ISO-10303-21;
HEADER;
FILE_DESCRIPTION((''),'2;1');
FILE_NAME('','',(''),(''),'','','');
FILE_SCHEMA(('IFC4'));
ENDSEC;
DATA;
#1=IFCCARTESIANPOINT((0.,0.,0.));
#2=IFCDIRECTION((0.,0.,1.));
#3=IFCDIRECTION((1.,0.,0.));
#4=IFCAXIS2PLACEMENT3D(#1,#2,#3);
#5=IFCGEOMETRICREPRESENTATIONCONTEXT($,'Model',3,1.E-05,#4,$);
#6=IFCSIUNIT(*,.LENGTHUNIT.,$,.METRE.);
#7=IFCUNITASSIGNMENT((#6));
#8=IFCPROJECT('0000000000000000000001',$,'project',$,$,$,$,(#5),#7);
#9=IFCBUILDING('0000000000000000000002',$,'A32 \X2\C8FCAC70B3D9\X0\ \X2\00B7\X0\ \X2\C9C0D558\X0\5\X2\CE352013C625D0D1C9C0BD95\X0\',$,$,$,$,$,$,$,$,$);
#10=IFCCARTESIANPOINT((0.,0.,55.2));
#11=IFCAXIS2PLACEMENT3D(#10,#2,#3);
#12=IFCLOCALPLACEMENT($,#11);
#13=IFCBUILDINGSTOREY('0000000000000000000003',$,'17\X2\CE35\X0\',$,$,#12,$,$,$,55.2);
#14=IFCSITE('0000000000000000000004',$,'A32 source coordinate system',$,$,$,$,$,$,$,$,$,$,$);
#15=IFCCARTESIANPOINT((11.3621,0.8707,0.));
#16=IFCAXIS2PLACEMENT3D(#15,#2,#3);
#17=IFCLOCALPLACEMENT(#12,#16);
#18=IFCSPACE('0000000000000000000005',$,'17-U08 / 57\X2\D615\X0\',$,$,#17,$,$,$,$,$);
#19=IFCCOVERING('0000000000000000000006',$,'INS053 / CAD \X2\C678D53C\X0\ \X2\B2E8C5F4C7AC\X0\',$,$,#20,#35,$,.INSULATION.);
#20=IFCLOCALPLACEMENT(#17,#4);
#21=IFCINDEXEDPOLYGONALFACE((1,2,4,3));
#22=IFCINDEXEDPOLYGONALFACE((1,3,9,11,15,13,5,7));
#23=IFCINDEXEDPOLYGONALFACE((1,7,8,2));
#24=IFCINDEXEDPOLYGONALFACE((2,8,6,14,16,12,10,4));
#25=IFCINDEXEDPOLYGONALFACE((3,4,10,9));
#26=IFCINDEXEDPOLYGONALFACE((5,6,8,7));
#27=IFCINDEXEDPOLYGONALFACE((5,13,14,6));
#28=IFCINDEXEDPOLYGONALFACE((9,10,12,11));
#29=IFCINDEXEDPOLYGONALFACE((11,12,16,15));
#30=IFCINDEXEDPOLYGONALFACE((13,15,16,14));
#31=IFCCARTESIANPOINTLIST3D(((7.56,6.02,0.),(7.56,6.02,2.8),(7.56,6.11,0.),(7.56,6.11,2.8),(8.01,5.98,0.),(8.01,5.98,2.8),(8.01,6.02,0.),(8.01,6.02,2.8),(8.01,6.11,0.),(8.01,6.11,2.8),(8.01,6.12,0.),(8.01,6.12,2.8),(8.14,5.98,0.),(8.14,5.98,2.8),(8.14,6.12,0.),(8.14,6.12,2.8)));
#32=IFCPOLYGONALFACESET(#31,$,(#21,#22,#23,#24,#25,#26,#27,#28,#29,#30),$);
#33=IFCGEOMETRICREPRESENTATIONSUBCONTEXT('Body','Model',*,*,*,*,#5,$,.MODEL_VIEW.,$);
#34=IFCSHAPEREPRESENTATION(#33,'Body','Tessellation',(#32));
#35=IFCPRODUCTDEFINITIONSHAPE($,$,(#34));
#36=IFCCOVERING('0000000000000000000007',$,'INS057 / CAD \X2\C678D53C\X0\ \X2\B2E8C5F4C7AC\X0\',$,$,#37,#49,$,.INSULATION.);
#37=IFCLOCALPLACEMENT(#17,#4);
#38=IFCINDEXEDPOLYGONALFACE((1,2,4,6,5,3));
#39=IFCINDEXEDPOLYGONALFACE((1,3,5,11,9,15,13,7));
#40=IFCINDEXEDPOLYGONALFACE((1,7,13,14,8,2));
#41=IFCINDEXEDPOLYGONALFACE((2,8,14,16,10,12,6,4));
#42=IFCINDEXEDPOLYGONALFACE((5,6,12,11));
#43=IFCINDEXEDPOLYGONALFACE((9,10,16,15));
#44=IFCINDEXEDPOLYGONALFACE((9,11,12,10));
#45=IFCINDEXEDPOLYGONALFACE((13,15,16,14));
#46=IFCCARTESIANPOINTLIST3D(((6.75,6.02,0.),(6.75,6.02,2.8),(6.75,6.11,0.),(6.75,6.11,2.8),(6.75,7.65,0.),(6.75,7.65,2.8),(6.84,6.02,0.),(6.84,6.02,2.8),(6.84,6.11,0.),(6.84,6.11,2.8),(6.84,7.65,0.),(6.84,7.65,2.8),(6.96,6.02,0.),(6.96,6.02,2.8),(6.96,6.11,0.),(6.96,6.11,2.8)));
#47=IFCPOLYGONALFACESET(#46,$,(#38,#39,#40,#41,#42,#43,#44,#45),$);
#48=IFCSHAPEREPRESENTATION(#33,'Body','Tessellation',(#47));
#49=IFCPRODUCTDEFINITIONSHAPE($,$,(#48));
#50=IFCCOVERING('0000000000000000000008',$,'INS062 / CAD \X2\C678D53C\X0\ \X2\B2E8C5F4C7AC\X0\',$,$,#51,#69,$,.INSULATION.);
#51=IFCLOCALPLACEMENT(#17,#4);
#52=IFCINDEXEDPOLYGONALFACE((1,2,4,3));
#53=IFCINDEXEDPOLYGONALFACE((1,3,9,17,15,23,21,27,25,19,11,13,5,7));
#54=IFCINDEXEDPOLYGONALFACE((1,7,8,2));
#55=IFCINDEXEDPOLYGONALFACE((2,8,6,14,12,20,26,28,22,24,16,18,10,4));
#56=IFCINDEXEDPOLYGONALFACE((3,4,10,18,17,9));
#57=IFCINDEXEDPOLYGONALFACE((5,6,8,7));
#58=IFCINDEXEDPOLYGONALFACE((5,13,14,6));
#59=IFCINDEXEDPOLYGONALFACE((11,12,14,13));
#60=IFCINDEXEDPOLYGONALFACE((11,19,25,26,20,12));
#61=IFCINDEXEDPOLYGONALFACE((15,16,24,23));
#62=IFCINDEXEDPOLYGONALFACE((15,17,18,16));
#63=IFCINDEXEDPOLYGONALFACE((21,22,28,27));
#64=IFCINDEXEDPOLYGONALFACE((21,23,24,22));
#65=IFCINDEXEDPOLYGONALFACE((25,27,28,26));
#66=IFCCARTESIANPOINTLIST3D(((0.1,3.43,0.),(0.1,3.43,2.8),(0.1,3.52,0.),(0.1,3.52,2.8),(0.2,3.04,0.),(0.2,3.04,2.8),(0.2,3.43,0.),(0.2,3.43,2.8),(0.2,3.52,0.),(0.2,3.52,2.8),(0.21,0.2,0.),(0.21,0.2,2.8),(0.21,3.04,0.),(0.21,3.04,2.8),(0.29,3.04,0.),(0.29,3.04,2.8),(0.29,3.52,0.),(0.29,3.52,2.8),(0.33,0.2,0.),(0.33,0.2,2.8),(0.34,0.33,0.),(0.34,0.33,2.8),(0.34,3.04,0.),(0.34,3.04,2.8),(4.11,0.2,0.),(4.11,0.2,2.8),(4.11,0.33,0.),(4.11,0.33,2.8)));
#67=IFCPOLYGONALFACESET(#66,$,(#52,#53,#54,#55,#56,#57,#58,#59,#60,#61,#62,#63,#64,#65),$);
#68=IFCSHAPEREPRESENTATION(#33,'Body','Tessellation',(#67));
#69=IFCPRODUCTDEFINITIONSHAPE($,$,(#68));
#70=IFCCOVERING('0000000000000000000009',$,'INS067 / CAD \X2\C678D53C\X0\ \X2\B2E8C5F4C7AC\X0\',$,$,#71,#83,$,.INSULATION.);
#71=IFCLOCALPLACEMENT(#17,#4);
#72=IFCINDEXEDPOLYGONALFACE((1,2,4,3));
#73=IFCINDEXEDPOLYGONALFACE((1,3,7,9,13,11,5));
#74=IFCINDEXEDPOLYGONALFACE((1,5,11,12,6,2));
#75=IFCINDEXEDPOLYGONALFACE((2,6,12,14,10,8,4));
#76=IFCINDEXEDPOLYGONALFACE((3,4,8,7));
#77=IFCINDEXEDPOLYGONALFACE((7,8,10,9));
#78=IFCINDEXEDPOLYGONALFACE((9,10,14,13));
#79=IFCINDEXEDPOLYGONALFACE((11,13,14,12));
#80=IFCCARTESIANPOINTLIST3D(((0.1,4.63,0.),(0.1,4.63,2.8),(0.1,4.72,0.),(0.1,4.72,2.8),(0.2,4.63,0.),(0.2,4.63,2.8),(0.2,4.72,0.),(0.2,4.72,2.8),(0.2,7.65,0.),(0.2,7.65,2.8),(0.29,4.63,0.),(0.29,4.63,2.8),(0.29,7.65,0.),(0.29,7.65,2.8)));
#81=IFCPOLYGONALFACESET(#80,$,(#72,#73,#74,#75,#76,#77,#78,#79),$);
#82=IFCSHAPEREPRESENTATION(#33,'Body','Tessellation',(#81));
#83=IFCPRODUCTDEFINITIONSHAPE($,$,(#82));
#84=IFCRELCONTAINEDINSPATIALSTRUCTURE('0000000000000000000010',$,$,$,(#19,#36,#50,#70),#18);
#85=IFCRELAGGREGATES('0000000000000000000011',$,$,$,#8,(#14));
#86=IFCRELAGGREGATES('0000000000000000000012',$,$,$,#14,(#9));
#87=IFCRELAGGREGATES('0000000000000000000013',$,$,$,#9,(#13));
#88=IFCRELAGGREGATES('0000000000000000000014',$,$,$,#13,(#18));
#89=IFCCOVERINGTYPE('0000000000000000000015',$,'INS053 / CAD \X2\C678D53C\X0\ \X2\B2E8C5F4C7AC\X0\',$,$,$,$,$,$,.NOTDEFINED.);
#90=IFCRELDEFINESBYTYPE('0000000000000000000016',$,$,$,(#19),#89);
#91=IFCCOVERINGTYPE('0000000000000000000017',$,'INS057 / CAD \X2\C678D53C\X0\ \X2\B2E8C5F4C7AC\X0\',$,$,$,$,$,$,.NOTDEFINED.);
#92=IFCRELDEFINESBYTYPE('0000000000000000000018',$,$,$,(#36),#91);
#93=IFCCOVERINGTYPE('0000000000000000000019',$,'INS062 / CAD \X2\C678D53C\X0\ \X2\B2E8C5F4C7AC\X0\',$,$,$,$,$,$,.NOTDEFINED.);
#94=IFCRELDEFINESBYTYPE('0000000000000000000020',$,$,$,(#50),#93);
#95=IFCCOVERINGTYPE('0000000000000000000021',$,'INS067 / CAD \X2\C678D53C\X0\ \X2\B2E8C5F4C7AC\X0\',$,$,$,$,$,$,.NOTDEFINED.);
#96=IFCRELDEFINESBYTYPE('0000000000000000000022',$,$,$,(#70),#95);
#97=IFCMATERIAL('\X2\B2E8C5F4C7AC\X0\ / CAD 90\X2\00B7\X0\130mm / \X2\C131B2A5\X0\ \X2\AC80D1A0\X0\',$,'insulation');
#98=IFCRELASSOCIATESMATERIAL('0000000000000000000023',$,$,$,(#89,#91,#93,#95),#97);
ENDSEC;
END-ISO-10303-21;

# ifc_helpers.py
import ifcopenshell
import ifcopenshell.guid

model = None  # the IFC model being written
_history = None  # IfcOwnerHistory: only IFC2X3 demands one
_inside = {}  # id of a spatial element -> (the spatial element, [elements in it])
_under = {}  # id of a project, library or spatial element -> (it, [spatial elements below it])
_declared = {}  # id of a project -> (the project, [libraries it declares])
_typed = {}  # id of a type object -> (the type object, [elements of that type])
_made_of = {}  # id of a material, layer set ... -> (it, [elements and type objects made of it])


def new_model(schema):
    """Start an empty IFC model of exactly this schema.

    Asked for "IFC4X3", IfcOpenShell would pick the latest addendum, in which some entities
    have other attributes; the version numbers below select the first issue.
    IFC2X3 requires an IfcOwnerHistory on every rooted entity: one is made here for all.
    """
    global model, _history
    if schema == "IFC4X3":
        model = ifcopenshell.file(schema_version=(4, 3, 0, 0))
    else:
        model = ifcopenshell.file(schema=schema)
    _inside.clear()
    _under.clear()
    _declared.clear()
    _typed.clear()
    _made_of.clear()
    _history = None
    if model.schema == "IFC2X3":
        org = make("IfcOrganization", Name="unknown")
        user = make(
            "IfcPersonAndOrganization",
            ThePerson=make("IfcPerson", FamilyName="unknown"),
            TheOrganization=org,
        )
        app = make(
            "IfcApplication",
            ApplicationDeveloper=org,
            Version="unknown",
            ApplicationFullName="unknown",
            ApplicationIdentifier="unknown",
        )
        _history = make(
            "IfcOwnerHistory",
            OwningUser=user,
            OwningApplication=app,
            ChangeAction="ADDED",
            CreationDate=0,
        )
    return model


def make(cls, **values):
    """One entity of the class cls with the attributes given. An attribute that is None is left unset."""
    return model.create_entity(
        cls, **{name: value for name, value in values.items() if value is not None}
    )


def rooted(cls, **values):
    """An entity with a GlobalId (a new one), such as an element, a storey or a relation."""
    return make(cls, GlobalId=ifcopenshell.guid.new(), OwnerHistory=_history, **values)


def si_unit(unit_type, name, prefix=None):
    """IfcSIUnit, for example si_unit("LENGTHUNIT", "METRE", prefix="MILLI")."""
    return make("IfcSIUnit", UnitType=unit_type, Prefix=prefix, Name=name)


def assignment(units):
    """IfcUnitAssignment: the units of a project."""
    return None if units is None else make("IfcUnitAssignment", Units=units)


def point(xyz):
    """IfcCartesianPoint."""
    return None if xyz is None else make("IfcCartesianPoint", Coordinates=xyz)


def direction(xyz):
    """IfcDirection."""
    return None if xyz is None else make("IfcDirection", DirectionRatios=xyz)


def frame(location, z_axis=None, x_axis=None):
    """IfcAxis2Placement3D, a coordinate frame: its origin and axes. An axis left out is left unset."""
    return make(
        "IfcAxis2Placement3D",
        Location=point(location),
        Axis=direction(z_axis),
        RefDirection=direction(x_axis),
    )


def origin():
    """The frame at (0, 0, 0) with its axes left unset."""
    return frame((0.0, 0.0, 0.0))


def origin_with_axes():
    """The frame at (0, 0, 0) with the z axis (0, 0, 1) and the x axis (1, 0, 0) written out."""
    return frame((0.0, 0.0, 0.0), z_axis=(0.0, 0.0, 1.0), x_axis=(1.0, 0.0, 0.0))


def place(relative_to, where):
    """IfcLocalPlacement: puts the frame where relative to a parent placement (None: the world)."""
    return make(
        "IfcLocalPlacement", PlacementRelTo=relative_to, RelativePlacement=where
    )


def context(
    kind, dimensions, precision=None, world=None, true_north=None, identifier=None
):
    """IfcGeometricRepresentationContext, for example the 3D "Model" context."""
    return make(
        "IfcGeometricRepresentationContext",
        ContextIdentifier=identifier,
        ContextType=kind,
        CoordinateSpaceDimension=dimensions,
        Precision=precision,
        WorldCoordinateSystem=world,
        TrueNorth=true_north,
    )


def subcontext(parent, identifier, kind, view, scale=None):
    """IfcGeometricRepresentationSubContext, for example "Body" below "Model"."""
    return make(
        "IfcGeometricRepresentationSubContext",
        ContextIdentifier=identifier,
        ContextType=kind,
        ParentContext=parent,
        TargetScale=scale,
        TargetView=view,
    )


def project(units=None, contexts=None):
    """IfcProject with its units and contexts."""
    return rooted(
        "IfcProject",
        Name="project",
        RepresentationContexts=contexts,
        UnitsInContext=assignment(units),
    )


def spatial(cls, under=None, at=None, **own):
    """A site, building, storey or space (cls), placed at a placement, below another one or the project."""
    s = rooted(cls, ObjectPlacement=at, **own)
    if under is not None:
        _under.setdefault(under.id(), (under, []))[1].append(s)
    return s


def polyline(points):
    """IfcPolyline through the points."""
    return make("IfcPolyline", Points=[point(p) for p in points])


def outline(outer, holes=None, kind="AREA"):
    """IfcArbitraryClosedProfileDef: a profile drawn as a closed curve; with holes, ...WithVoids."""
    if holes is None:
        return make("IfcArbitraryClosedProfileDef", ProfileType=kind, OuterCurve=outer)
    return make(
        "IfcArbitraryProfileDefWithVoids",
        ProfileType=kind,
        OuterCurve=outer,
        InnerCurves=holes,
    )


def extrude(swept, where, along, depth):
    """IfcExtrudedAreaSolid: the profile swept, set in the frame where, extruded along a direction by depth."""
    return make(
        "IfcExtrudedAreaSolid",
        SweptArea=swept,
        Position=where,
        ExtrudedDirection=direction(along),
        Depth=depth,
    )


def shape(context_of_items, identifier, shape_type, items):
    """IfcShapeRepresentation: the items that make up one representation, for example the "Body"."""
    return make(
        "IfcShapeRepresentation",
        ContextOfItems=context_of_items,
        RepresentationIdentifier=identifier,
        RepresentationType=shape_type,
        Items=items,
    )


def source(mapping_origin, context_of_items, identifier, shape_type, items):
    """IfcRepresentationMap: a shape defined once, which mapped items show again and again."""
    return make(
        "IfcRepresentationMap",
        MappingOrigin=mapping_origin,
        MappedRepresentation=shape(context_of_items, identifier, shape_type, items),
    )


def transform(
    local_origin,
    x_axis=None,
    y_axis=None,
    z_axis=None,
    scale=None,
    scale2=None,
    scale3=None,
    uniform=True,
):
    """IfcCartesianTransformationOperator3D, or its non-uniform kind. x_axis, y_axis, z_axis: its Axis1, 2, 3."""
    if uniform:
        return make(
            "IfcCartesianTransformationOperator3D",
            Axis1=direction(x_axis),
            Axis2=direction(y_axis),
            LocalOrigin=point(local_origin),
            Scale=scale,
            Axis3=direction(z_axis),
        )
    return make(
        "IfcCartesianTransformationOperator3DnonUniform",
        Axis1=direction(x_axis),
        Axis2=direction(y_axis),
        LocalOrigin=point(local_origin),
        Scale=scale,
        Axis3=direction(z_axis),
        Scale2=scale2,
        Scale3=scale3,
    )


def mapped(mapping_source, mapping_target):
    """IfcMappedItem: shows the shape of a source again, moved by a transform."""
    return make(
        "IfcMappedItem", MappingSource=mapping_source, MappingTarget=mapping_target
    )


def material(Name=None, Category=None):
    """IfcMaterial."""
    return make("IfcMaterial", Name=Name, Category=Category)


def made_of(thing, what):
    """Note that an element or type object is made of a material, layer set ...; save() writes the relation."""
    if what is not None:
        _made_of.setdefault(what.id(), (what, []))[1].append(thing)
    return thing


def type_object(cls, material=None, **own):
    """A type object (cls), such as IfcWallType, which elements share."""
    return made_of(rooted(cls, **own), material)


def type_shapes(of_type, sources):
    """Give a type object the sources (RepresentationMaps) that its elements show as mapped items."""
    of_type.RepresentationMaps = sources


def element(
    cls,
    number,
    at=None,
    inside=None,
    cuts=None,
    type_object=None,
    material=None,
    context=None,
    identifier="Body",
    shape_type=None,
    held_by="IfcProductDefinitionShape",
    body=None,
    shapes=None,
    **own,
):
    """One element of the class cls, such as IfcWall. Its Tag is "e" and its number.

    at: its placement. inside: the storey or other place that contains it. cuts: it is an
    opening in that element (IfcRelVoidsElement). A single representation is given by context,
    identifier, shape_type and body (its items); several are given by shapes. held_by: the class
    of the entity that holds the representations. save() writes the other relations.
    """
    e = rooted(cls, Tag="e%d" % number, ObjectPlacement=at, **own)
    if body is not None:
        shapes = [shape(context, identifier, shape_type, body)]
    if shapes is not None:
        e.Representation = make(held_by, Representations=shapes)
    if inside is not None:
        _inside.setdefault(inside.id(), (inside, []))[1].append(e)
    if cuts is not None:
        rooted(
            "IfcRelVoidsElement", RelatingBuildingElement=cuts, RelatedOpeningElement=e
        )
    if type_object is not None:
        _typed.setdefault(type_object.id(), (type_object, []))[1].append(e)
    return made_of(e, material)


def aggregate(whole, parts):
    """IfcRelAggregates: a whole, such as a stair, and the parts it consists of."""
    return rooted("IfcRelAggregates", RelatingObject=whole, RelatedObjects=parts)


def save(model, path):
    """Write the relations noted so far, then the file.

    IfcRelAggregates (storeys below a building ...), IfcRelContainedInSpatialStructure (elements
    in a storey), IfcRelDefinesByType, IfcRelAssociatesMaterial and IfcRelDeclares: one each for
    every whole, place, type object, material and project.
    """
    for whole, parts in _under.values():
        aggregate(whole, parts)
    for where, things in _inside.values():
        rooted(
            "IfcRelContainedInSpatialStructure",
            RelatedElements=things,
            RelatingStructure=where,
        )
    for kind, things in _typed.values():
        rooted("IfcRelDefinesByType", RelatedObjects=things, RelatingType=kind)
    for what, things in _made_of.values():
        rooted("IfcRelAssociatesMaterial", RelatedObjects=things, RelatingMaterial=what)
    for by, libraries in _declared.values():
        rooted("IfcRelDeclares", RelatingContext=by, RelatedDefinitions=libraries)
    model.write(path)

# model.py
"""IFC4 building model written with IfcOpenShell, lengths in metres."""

from ifc_helpers import new_model, si_unit, frame, origin, origin_with_axes, place, context, subcontext, project, spatial, polyline, outline, extrude, source, transform, mapped, material, type_object, type_shapes, element, save


model = new_model("IFC4")

# Units and contexts
model_context = context("Model", 3, precision=1e-05, world=origin_with_axes())
body_context = subcontext(model_context, "Body", "Model", "MODEL_VIEW")
ifc_project = project(units=[si_unit("LENGTHUNIT", "METRE")], contexts=[model_context])

# Site, building, storey, space
site = spatial("IfcSite", under=ifc_project, Name="A32 source coordinate system")
building = spatial("IfcBuilding", under=site, Name="A32 주거동 · 지하5층–옥탑지붕")
storey_placement = place(None, frame((0.0, 0.0, 55.2), z_axis=(0.0, 0.0, 1.0), x_axis=(1.0, 0.0, 0.0)))
storey = spatial("IfcBuildingStorey", under=building, at=storey_placement, Name="17층", Elevation=55.2)
space_1_placement = place(storey_placement, frame((11.3621, 0.8707, 0.0), z_axis=(0.0, 0.0, 1.0), x_axis=(1.0, 0.0, 0.0)))
space_1 = spatial("IfcSpace", under=storey, at=space_1_placement, Name="17-U08 / 57형")

# Coverings
ifc_material = material(Name="단열재 / CAD 90·130mm / 성능 검토", Category="insulation")
covering_type_1 = type_object("IfcCoveringType", Name="INS053 / CAD 외피 단열재", PredefinedType="NOTDEFINED", material=ifc_material)
shared_shape_1 = source(origin(), body_context, "Body", "SweptSolid", [
    extrude(outline(polyline([(8.01, 6.12), (8.14, 6.12), (8.14, 5.98), (8.01, 5.98), (8.01, 6.02), (7.56, 6.02), (7.56, 6.11), (8.01, 6.11), (8.01, 6.12)])), origin(), (0.0, 0.0, 1.0), 2.8),
])
type_shapes(covering_type_1, [shared_shape_1])
covering_1_placement = place(space_1_placement, origin_with_axes())
element("IfcCovering", 1, at=covering_1_placement, inside=space_1, type_object=covering_type_1, Name="INS053 / CAD 외피 단열재", PredefinedType="INSULATION", context=body_context, shape_type="MappedRepresentation", body=[
    mapped(shared_shape_1, transform((0.0, 0.0, 0.0), scale=1.0)),
])
covering_type_2 = type_object("IfcCoveringType", Name="INS057 / CAD 외피 단열재", PredefinedType="NOTDEFINED", material=ifc_material)
shared_shape_2 = source(origin(), body_context, "Body", "SweptSolid", [
    extrude(outline(polyline([(6.84, 6.11), (6.96, 6.11), (6.96, 6.02), (6.84, 6.02), (6.75, 6.02), (6.75, 6.11), (6.75, 7.65), (6.84, 7.65), (6.84, 6.11)])), origin(), (0.0, 0.0, 1.0), 2.8),
])
type_shapes(covering_type_2, [shared_shape_2])
covering_2_placement = place(space_1_placement, origin_with_axes())
element("IfcCovering", 2, at=covering_2_placement, inside=space_1, type_object=covering_type_2, Name="INS057 / CAD 외피 단열재", PredefinedType="INSULATION", context=body_context, shape_type="MappedRepresentation", body=[
    mapped(shared_shape_2, transform((0.0, 0.0, 0.0), scale=1.0)),
])
covering_type_3 = type_object("IfcCoveringType", Name="INS062 / CAD 외피 단열재", PredefinedType="NOTDEFINED", material=ifc_material)
shared_shape_3 = source(origin(), body_context, "Body", "SweptSolid", [
    extrude(outline(polyline([(4.11, 0.2), (0.33, 0.2), (0.21, 0.2), (0.21, 3.04), (0.2, 3.04), (0.2, 3.43), (0.1, 3.43), (0.1, 3.52), (0.2, 3.52), (0.29, 3.52), (0.29, 3.04), (0.34, 3.04), (0.34, 0.33), (4.11, 0.33), (4.11, 0.2)])), origin(), (0.0, 0.0, 1.0), 2.8),
])
type_shapes(covering_type_3, [shared_shape_3])
covering_3_placement = place(space_1_placement, origin_with_axes())
element("IfcCovering", 3, at=covering_3_placement, inside=space_1, type_object=covering_type_3, Name="INS062 / CAD 외피 단열재", PredefinedType="INSULATION", context=body_context, shape_type="MappedRepresentation", body=[
    mapped(shared_shape_3, transform((0.0, 0.0, 0.0), scale=1.0)),
])
covering_type_4 = type_object("IfcCoveringType", Name="INS067 / CAD 외피 단열재", PredefinedType="NOTDEFINED", material=ifc_material)
shared_shape_4 = source(origin(), body_context, "Body", "SweptSolid", [
    extrude(outline(polyline([(0.1, 4.72), (0.2, 4.72), (0.2, 7.65), (0.29, 7.65), (0.29, 4.63), (0.2, 4.63), (0.1, 4.63), (0.1, 4.72)])), origin(), (0.0, 0.0, 1.0), 2.8),
])
type_shapes(covering_type_4, [shared_shape_4])
covering_4_placement = place(space_1_placement, origin_with_axes())
element("IfcCovering", 4, at=covering_4_placement, inside=space_1, type_object=covering_type_4, Name="INS067 / CAD 외피 단열재", PredefinedType="INSULATION", context=body_context, shape_type="MappedRepresentation", body=[
    mapped(shared_shape_4, transform((0.0, 0.0, 0.0), scale=1.0)),
])

save(model, "model.ifc")
